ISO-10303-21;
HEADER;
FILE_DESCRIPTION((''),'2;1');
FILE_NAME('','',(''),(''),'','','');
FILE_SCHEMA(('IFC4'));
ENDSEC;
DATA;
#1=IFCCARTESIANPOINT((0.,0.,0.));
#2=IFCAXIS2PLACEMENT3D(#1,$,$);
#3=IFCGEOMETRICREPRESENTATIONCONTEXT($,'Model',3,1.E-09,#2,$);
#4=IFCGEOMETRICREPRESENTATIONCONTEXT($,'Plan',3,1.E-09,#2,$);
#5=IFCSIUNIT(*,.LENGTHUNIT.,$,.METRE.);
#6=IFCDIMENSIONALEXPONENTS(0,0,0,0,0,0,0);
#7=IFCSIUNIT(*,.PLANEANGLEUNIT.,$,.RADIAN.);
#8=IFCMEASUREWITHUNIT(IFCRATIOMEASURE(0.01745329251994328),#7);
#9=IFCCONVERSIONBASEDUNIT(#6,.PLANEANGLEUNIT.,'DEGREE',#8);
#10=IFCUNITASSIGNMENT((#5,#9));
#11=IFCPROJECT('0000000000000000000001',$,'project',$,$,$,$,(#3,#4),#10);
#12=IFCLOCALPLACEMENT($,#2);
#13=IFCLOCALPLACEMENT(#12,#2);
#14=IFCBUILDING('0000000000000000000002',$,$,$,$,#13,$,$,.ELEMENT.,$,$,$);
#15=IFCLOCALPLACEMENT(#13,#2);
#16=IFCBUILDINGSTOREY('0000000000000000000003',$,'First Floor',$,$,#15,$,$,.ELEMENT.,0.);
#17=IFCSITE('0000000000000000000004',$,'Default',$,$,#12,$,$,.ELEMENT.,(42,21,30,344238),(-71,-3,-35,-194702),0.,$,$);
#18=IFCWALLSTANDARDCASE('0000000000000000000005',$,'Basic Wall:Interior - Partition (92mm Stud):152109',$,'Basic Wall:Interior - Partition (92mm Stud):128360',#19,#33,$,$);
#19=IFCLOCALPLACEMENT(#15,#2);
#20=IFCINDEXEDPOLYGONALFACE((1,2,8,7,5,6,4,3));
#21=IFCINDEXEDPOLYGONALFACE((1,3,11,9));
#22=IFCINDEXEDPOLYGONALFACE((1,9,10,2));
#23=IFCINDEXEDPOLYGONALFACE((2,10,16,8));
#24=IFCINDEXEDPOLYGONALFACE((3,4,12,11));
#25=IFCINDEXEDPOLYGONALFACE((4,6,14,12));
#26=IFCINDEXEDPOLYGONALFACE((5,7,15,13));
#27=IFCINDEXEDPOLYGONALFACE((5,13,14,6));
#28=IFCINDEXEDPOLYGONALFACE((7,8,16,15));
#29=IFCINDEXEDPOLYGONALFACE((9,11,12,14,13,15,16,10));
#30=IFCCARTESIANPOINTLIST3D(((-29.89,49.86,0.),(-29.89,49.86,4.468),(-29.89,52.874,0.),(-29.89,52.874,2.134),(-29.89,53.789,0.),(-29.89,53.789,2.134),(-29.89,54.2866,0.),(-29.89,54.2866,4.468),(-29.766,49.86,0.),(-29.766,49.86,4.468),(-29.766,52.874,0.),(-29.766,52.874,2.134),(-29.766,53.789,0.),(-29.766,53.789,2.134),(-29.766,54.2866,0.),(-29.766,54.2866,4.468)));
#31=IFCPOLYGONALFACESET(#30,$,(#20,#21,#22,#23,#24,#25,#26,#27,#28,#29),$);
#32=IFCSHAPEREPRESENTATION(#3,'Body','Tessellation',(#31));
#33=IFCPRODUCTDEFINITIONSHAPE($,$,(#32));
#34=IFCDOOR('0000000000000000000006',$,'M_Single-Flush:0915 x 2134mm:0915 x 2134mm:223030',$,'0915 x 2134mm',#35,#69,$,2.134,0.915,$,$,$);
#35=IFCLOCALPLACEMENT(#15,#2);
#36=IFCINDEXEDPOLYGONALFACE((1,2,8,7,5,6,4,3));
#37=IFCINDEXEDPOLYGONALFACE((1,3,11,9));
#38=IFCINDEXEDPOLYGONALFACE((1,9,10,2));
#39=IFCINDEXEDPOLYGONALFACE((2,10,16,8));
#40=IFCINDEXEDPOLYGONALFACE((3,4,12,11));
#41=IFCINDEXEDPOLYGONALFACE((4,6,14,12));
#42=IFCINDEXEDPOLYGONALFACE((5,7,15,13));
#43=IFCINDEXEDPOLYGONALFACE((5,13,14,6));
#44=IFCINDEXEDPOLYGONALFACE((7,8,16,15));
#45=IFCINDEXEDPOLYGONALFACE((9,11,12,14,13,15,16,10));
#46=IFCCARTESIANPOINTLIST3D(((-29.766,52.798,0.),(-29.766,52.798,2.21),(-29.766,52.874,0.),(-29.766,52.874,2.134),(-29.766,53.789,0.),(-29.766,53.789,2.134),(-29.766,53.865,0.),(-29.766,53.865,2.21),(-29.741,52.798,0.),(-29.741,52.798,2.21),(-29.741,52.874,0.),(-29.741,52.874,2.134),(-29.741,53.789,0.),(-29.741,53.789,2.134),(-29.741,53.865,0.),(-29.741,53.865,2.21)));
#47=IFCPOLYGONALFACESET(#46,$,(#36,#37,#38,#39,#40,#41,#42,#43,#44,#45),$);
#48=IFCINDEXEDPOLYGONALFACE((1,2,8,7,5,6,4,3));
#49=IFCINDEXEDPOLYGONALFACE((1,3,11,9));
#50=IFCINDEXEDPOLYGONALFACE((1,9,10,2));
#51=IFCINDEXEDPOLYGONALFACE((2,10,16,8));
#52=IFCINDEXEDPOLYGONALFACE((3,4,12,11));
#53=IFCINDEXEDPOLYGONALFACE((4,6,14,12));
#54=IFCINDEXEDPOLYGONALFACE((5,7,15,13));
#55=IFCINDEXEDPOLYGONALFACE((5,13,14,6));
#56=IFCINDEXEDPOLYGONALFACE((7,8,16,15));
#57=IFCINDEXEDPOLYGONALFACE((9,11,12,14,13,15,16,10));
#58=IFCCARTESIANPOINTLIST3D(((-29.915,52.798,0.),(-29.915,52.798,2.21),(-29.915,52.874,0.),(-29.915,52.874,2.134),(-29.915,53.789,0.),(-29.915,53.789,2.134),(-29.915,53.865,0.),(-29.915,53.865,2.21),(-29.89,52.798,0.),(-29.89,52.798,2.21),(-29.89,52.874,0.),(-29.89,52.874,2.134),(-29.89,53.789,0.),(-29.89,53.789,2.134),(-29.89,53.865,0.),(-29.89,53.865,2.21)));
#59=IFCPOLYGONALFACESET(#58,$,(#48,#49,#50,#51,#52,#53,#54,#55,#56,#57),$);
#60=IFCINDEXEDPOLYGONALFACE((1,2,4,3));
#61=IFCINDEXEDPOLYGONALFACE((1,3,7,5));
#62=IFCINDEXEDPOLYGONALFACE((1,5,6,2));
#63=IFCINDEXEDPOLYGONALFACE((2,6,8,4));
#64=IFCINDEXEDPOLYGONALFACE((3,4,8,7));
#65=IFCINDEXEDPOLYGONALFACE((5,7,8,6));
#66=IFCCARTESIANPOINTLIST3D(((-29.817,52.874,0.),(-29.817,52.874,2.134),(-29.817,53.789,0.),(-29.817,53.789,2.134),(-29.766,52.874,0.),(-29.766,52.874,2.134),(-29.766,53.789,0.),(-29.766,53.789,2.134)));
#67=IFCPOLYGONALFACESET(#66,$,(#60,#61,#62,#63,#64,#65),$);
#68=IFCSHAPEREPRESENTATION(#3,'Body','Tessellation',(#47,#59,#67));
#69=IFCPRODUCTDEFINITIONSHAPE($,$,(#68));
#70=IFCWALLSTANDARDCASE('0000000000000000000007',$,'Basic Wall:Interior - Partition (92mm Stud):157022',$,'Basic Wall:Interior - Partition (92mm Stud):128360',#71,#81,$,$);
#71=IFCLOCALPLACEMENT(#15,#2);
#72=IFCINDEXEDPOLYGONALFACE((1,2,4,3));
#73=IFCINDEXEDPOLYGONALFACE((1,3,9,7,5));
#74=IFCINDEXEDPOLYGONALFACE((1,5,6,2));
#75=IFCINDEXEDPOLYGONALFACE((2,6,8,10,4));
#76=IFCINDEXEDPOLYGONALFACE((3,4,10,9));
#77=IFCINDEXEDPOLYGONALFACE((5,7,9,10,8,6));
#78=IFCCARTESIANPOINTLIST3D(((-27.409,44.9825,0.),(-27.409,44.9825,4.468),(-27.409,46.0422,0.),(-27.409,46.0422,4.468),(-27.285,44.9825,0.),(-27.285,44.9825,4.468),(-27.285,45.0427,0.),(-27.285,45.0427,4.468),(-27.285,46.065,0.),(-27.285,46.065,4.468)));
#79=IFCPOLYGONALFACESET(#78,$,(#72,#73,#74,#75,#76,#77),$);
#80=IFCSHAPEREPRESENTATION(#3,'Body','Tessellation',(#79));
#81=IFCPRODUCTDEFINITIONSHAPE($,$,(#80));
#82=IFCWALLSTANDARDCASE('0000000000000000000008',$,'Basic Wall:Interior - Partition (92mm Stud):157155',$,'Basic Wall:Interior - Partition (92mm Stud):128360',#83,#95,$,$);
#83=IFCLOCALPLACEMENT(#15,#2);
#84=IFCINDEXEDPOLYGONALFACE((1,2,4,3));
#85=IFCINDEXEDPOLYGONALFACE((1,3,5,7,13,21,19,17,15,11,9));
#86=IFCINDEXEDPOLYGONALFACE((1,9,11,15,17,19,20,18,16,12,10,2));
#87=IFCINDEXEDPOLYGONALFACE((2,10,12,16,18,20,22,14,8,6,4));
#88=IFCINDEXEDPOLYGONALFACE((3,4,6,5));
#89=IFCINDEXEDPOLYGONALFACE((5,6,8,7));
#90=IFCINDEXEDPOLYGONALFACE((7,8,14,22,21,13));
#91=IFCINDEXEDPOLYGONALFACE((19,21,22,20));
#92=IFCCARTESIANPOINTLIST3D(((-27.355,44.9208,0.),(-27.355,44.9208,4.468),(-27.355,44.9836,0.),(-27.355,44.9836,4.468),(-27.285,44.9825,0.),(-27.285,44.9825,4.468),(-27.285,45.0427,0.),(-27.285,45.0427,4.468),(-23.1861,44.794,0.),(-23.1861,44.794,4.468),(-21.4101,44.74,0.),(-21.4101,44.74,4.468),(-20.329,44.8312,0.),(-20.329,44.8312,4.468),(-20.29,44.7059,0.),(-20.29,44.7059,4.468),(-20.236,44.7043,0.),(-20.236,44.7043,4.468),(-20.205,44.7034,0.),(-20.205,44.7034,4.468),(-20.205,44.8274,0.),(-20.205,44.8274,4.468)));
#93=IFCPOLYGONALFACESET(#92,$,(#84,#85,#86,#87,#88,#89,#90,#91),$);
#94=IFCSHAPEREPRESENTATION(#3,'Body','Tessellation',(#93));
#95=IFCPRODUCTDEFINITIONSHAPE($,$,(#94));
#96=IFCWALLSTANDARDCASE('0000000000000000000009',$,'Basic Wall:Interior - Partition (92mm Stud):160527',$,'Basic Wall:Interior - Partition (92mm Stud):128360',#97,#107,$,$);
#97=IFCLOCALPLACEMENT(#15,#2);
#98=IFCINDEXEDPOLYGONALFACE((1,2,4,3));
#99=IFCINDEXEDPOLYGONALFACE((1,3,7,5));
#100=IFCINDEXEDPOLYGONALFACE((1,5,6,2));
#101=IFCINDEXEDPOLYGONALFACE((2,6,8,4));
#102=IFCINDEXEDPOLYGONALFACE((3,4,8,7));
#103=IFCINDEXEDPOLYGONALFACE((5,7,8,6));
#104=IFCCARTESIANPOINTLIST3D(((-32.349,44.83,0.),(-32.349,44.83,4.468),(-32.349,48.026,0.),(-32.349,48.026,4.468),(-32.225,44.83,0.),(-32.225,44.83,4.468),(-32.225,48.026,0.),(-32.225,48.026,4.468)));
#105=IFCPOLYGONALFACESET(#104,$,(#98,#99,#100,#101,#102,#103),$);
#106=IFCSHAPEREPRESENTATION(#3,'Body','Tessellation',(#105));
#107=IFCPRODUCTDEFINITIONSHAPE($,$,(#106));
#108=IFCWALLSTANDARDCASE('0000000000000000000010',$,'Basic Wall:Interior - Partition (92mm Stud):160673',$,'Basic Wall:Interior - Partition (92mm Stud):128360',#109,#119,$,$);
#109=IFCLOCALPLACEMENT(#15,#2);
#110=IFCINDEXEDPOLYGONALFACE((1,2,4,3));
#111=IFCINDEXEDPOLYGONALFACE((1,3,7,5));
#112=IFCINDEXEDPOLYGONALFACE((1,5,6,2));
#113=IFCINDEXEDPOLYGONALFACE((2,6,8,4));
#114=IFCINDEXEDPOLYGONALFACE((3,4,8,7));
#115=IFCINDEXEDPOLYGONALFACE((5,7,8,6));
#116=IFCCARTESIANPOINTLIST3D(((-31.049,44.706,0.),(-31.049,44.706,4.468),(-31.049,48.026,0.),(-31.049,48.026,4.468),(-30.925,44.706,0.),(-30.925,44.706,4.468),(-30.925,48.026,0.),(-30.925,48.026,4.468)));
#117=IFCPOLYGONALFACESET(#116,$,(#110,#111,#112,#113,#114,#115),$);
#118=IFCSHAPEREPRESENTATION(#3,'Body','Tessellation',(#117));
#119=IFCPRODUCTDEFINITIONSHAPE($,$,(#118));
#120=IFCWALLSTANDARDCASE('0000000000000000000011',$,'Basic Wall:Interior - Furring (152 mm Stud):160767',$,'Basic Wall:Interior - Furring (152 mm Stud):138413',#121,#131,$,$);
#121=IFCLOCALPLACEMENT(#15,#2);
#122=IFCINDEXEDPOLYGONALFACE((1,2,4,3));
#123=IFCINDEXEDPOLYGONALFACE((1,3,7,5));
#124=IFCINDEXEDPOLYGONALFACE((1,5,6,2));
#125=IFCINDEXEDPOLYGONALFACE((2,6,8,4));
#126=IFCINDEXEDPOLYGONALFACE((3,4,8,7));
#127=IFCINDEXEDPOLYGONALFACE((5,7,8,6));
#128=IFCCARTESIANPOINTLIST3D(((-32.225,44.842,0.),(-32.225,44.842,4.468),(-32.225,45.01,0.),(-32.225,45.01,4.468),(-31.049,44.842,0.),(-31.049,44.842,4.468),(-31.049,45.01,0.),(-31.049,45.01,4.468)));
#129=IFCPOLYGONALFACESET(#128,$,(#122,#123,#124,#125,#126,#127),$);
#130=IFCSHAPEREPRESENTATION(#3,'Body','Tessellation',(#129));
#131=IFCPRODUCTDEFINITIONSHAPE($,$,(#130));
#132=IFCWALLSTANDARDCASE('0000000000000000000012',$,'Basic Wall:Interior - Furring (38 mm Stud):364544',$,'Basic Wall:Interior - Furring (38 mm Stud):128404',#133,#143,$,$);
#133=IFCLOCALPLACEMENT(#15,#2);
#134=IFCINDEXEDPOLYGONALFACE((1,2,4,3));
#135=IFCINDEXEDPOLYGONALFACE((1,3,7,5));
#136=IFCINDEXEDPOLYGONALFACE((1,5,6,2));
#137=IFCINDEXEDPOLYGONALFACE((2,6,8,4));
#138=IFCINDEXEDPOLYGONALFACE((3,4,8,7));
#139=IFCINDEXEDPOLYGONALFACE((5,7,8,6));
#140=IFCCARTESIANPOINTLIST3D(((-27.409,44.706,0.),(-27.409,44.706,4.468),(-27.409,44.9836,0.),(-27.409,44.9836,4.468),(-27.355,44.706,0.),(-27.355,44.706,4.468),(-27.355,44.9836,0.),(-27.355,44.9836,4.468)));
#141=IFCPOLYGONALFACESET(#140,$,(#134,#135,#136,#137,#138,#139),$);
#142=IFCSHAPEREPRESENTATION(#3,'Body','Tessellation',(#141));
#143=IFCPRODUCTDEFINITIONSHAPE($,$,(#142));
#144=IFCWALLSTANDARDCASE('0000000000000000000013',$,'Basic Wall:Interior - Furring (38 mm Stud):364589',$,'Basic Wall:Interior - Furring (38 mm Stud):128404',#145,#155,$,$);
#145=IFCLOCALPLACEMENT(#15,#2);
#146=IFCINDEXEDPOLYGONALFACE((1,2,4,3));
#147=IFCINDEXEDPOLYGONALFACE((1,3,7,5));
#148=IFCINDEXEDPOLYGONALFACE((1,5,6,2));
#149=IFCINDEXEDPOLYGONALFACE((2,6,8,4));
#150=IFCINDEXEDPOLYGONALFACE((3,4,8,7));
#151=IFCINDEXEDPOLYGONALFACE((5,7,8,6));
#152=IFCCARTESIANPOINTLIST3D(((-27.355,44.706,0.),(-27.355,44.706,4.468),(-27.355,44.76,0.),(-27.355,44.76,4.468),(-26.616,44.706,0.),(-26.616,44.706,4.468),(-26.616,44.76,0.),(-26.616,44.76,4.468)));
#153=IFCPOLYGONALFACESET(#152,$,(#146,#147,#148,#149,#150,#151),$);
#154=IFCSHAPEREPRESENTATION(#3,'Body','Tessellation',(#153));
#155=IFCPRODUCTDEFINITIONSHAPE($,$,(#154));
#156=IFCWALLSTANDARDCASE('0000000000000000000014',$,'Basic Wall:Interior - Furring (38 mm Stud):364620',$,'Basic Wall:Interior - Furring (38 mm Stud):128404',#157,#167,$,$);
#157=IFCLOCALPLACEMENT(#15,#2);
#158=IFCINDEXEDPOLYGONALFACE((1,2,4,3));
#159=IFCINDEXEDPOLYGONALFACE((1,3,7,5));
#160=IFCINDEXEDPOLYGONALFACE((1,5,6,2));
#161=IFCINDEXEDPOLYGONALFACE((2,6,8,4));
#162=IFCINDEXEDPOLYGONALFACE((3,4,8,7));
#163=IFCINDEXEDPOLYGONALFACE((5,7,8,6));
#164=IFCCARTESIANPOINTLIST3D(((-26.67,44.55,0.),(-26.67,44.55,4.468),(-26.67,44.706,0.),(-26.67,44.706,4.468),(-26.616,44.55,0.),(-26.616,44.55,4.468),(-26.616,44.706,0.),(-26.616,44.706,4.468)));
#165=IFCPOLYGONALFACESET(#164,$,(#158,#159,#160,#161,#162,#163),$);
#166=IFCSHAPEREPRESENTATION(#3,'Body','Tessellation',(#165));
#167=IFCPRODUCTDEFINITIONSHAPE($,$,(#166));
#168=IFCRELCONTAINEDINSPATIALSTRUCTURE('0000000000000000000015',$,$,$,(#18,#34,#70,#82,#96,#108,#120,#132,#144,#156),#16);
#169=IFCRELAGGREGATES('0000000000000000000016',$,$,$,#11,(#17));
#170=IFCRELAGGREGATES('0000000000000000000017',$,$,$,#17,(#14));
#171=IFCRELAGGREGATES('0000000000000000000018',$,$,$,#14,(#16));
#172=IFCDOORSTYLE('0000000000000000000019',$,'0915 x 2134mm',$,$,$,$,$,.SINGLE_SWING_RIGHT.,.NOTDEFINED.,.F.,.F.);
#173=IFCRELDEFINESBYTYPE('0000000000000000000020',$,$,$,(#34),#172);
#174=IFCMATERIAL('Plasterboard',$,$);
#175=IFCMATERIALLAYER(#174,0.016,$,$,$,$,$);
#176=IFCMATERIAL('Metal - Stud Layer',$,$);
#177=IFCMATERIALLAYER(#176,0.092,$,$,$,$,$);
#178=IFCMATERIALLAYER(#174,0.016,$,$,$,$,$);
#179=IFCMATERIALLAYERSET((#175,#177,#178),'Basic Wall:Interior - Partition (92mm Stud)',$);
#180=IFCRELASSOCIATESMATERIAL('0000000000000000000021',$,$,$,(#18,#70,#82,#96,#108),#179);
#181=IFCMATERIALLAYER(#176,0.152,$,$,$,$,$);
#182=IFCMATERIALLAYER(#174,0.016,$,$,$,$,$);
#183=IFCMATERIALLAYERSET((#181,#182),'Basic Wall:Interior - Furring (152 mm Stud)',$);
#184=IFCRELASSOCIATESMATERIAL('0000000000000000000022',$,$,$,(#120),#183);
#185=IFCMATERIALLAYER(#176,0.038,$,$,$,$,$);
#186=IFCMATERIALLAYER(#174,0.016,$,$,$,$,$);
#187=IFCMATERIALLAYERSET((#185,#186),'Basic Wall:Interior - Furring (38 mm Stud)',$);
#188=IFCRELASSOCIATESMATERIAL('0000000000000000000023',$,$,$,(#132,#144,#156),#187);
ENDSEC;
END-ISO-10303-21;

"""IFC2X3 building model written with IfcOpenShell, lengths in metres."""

from ifc_helpers import new_model, entity, si_unit, converted_unit, frame, frame_2d, origin, origin_2d_with_axis, place, context, project, spatial, polyline, rectangle, outline, extrude, source, transform, mapped, material, layer, layer_set, layer_usage, type_object, type_shapes, element, fill, save


model = new_model("IFC2X3")

# Units and contexts
model_context = context("Model", 3, precision=1e-09, world=origin())
plan_context = context("Plan", 3, precision=1e-09, world=origin())
ifc_project = project(units=[si_unit("LENGTHUNIT", "METRE"), converted_unit("PLANEANGLEUNIT", "DEGREE", entity("IfcRatioMeasure", 0.01745329251994328), si_unit("PLANEANGLEUNIT", "RADIAN"), dimensions=[0, 0, 0, 0, 0, 0, 0])], contexts=[model_context, plan_context])

# Site, building, storey
site_placement = place(None, origin())
site = spatial("IfcSite", under=ifc_project, at=site_placement, Name="Default", CompositionType="ELEMENT", RefLatitude=(42, 21, 30, 344238), RefLongitude=(-71, -3, -35, -194702), RefElevation=0.0)
building_placement = place(site_placement, origin())
building = spatial("IfcBuilding", under=site, at=building_placement, CompositionType="ELEMENT")
storey_placement = place(building_placement, origin())
storey = spatial("IfcBuildingStorey", under=building, at=storey_placement, Name="First Floor", CompositionType="ELEMENT", Elevation=0.0)

# Wall, opening, door
ifc_material_1 = material(Name="Plasterboard")
ifc_layer_1 = layer(ifc_material_1, 0.016)
ifc_material_2 = material(Name="Metal - Stud Layer")
ifc_layer_2 = layer(ifc_material_2, 0.092)
ifc_layer_3 = layer(ifc_material_1, 0.016)
ifc_layer_set_1 = layer_set([ifc_layer_1, ifc_layer_2, ifc_layer_3], Name="Basic Wall:Interior - Partition (92mm Stud)")
ifc_layer_usage_1 = layer_usage(ifc_layer_set_1, "AXIS2", "NEGATIVE", 0.062)
wall_1_placement = place(storey_placement, frame((-29.828, 49.86, 0.0), z_axis=(0.0, 0.0, 1.0), x_axis=(0.0, 1.0, 0.0)))
wall_1 = element("IfcWallStandardCase", 1, at=wall_1_placement, inside=storey, material=ifc_layer_usage_1, Name="Basic Wall:Interior - Partition (92mm Stud):152109", ObjectType="Basic Wall:Interior - Partition (92mm Stud):128360", context=model_context, shape_type="SweptSolid", body=[
    extrude(rectangle(XDim=4.4266, YDim=0.124, at=frame_2d((2.2133, 0.0), x_axis=(-1.0, 0.0))), origin(), (0.0, 0.0, 1.0), 4.468),
])
opening_1_placement = place(wall_1_placement, frame((3.929, 0.062, 0.0)))
opening_1 = element("IfcOpeningElement", 2, at=opening_1_placement, cuts=wall_1, ObjectType="Opening", context=model_context, shape_type="SweptSolid", body=[
    extrude(rectangle(XDim=0.915, YDim=2.134, at=frame_2d((1.067, 0.4575), x_axis=(0.0, 1.0))), frame((0.0, 0.0, 0.0), z_axis=(0.0, -1.0, 0.0), x_axis=(0.0, 0.0, 1.0)), (0.0, 0.0, 1.0), 0.124),
])
door_style = type_object("IfcDoorStyle", Name="0915 x 2134mm", ConstructionType="NOTDEFINED", OperationType="SINGLE_SWING_RIGHT", ParameterTakesPrecedence=False, Sizeable=False)
shared_shape_1 = source(origin(), model_context, "Body", "SweptSolid", [
    extrude(outline(polyline([(-0.5335, -1.124), (0.5335, -1.124), (0.5335, 1.086), (0.4575, 1.086), (0.4575, -1.048), (-0.4575, -1.048), (-0.4575, 1.086), (-0.5335, 1.086), (-0.5335, -1.124)])), frame((0.4575, 0.124, 1.086), z_axis=(0.0, 1.0, 0.0), x_axis=(1.0, 0.0, 0.0)), (0.0, 0.0, 1.0), 0.025),
    extrude(outline(polyline([(-1.124, -0.5335), (1.086, -0.5335), (1.086, -0.4575), (-1.048, -0.4575), (-1.048, 0.4575), (1.086, 0.4575), (1.086, 0.5335), (-1.124, 0.5335), (-1.124, -0.5335)])), frame((0.4575, -0.025, 1.086), z_axis=(0.0, 1.0, 0.0), x_axis=(0.0, 0.0, -1.0)), (0.0, 0.0, 1.0), 0.025),
    extrude(rectangle(XDim=0.051, YDim=0.915, at=origin_2d_with_axis()), frame((0.4575, 0.0985, 0.0), z_axis=(0.0, 0.0, 1.0), x_axis=(0.0, 1.0, 0.0)), (0.0, 0.0, 1.0), 2.134),
])
type_shapes(door_style, [shared_shape_1])
door_placement = place(opening_1_placement, frame((0.0, 0.0, 0.0), z_axis=(0.0, 0.0, 1.0), x_axis=(-1.0, 0.0, 0.0)))
door = element("IfcDoor", 3, at=door_placement, inside=storey, type_object=door_style, Name="M_Single-Flush:0915 x 2134mm:0915 x 2134mm:223030", ObjectType="0915 x 2134mm", OverallHeight=2.134, OverallWidth=0.915, context=model_context, shape_type="MappedRepresentation", body=[
    mapped(shared_shape_1, transform((0.0, 0.0, 0.0), scale=1.0)),
])
fill(opening_1, door)

# Walls
ifc_layer_usage_2 = layer_usage(ifc_layer_set_1, "AXIS2", "NEGATIVE", 0.062)
wall_2_placement = place(storey_placement, frame((-27.347, 46.065, 0.0), z_axis=(0.0, 0.0, 1.0), x_axis=(0.0, -1.0, 0.0)))
element("IfcWallStandardCase", 4, at=wall_2_placement, inside=storey, material=ifc_layer_usage_2, Name="Basic Wall:Interior - Partition (92mm Stud):157022", ObjectType="Basic Wall:Interior - Partition (92mm Stud):128360", context=model_context, shape_type="SweptSolid", body=[
    extrude(outline(polyline([(1.0825, -0.062), (1.0825, 0.062), (1.0223, 0.062), (0.0, 0.062), (0.0228, -0.062), (1.0825, -0.062)])), origin(), (0.0, 0.0, 1.0), 4.468),
])
ifc_layer_usage_3 = layer_usage(ifc_layer_set_1, "AXIS2", "NEGATIVE", 0.062)
wall_3_placement = place(storey_placement, frame((-27.3531, 44.9827, 0.0), z_axis=(0.0, 0.0, 1.0), x_axis=(0.999538, -0.030391, 0.0)))
element("IfcWallStandardCase", 5, at=wall_3_placement, inside=storey, material=ifc_layer_usage_3, Name="Basic Wall:Interior - Partition (92mm Stud):157155", ObjectType="Basic Wall:Interior - Partition (92mm Stud):128360", context=model_context, shape_type="SweptSolid", body=[
    extrude(outline(polyline([(7.1533, -0.062), (7.1495, 0.062), (7.0255, 0.062), (0.0663, 0.062), (0.0681, 0.0019), (-0.0019, 0.0008), (0.0, -0.062), (4.1708, -0.062), (5.9476, -0.062), (7.0683, -0.062), (7.1223, -0.062), (7.1533, -0.062)])), origin(), (0.0, 0.0, 1.0), 4.468),
])
ifc_layer_usage_4 = layer_usage(ifc_layer_set_1, "AXIS2", "NEGATIVE", 0.062)
wall_4_placement = place(storey_placement, frame((-32.287, 48.026, 0.0), z_axis=(0.0, 0.0, 1.0), x_axis=(0.0, -1.0, 0.0)))
element("IfcWallStandardCase", 6, at=wall_4_placement, inside=storey, material=ifc_layer_usage_4, Name="Basic Wall:Interior - Partition (92mm Stud):160527", ObjectType="Basic Wall:Interior - Partition (92mm Stud):128360", context=model_context, shape_type="SweptSolid", body=[
    extrude(rectangle(XDim=3.196, YDim=0.124, at=frame_2d((1.598, 0.0), x_axis=(-1.0, 0.0))), origin(), (0.0, 0.0, 1.0), 4.468),
])
ifc_layer_usage_5 = layer_usage(ifc_layer_set_1, "AXIS2", "NEGATIVE", 0.062)
wall_5_placement = place(storey_placement, frame((-30.987, 48.026, 0.0), z_axis=(0.0, 0.0, 1.0), x_axis=(0.0, -1.0, 0.0)))
element("IfcWallStandardCase", 7, at=wall_5_placement, inside=storey, material=ifc_layer_usage_5, Name="Basic Wall:Interior - Partition (92mm Stud):160673", ObjectType="Basic Wall:Interior - Partition (92mm Stud):128360", context=model_context, shape_type="SweptSolid", body=[
    extrude(rectangle(XDim=3.32, YDim=0.124, at=frame_2d((1.66, 0.0), x_axis=(-1.0, 0.0))), origin(), (0.0, 0.0, 1.0), 4.468),
])
ifc_layer_4 = layer(ifc_material_2, 0.152)
ifc_layer_5 = layer(ifc_material_1, 0.016)
ifc_layer_set_2 = layer_set([ifc_layer_4, ifc_layer_5], Name="Basic Wall:Interior - Furring (152 mm Stud)")
ifc_layer_usage_6 = layer_usage(ifc_layer_set_2, "AXIS2", "POSITIVE", -0.084)
wall_6_placement = place(storey_placement, frame((-32.225, 44.926, 0.0)))
element("IfcWallStandardCase", 8, at=wall_6_placement, inside=storey, material=ifc_layer_usage_6, Name="Basic Wall:Interior - Furring (152 mm Stud):160767", ObjectType="Basic Wall:Interior - Furring (152 mm Stud):138413", context=model_context, shape_type="SweptSolid", body=[
    extrude(rectangle(XDim=1.176, YDim=0.168, at=frame_2d((0.588, 0.0), x_axis=(-1.0, 0.0))), origin(), (0.0, 0.0, 1.0), 4.468),
])
ifc_layer_6 = layer(ifc_material_2, 0.038)
ifc_layer_7 = layer(ifc_material_1, 0.016)
ifc_layer_set_3 = layer_set([ifc_layer_6, ifc_layer_7], Name="Basic Wall:Interior - Furring (38 mm Stud)")
ifc_layer_usage_7 = layer_usage(ifc_layer_set_3, "AXIS2", "NEGATIVE", 0.027)
wall_7_placement = place(storey_placement, frame((-27.382, 44.9836, 0.0), z_axis=(0.0, 0.0, 1.0), x_axis=(0.0, -1.0, 0.0)))
element("IfcWallStandardCase", 9, at=wall_7_placement, inside=storey, material=ifc_layer_usage_7, Name="Basic Wall:Interior - Furring (38 mm Stud):364544", ObjectType="Basic Wall:Interior - Furring (38 mm Stud):128404", context=model_context, shape_type="SweptSolid", body=[
    extrude(rectangle(XDim=0.2776, YDim=0.054, at=frame_2d((0.1388, 0.0), x_axis=(-1.0, 0.0))), origin(), (0.0, 0.0, 1.0), 4.468),
])
ifc_layer_usage_8 = layer_usage(ifc_layer_set_3, "AXIS2", "NEGATIVE", 0.027)
wall_8_placement = place(storey_placement, frame((-27.355, 44.733, 0.0)))
element("IfcWallStandardCase", 10, at=wall_8_placement, inside=storey, material=ifc_layer_usage_8, Name="Basic Wall:Interior - Furring (38 mm Stud):364589", ObjectType="Basic Wall:Interior - Furring (38 mm Stud):128404", context=model_context, shape_type="SweptSolid", body=[
    extrude(rectangle(XDim=0.739, YDim=0.054, at=frame_2d((0.3695, 0.0), x_axis=(-1.0, 0.0))), origin(), (0.0, 0.0, 1.0), 4.468),
])
ifc_layer_usage_9 = layer_usage(ifc_layer_set_3, "AXIS2", "NEGATIVE", 0.027)
wall_9_placement = place(storey_placement, frame((-26.643, 44.706, 0.0), z_axis=(0.0, 0.0, 1.0), x_axis=(0.0, -1.0, 0.0)))
element("IfcWallStandardCase", 11, at=wall_9_placement, inside=storey, material=ifc_layer_usage_9, Name="Basic Wall:Interior - Furring (38 mm Stud):364620", ObjectType="Basic Wall:Interior - Furring (38 mm Stud):128404", context=model_context, shape_type="SweptSolid", body=[
    extrude(rectangle(XDim=0.156, YDim=0.054, at=frame_2d((0.078, 0.0), x_axis=(-1.0, 0.0))), origin(), (0.0, 0.0, 1.0), 4.468),
])

save(model, "model.ifc")
